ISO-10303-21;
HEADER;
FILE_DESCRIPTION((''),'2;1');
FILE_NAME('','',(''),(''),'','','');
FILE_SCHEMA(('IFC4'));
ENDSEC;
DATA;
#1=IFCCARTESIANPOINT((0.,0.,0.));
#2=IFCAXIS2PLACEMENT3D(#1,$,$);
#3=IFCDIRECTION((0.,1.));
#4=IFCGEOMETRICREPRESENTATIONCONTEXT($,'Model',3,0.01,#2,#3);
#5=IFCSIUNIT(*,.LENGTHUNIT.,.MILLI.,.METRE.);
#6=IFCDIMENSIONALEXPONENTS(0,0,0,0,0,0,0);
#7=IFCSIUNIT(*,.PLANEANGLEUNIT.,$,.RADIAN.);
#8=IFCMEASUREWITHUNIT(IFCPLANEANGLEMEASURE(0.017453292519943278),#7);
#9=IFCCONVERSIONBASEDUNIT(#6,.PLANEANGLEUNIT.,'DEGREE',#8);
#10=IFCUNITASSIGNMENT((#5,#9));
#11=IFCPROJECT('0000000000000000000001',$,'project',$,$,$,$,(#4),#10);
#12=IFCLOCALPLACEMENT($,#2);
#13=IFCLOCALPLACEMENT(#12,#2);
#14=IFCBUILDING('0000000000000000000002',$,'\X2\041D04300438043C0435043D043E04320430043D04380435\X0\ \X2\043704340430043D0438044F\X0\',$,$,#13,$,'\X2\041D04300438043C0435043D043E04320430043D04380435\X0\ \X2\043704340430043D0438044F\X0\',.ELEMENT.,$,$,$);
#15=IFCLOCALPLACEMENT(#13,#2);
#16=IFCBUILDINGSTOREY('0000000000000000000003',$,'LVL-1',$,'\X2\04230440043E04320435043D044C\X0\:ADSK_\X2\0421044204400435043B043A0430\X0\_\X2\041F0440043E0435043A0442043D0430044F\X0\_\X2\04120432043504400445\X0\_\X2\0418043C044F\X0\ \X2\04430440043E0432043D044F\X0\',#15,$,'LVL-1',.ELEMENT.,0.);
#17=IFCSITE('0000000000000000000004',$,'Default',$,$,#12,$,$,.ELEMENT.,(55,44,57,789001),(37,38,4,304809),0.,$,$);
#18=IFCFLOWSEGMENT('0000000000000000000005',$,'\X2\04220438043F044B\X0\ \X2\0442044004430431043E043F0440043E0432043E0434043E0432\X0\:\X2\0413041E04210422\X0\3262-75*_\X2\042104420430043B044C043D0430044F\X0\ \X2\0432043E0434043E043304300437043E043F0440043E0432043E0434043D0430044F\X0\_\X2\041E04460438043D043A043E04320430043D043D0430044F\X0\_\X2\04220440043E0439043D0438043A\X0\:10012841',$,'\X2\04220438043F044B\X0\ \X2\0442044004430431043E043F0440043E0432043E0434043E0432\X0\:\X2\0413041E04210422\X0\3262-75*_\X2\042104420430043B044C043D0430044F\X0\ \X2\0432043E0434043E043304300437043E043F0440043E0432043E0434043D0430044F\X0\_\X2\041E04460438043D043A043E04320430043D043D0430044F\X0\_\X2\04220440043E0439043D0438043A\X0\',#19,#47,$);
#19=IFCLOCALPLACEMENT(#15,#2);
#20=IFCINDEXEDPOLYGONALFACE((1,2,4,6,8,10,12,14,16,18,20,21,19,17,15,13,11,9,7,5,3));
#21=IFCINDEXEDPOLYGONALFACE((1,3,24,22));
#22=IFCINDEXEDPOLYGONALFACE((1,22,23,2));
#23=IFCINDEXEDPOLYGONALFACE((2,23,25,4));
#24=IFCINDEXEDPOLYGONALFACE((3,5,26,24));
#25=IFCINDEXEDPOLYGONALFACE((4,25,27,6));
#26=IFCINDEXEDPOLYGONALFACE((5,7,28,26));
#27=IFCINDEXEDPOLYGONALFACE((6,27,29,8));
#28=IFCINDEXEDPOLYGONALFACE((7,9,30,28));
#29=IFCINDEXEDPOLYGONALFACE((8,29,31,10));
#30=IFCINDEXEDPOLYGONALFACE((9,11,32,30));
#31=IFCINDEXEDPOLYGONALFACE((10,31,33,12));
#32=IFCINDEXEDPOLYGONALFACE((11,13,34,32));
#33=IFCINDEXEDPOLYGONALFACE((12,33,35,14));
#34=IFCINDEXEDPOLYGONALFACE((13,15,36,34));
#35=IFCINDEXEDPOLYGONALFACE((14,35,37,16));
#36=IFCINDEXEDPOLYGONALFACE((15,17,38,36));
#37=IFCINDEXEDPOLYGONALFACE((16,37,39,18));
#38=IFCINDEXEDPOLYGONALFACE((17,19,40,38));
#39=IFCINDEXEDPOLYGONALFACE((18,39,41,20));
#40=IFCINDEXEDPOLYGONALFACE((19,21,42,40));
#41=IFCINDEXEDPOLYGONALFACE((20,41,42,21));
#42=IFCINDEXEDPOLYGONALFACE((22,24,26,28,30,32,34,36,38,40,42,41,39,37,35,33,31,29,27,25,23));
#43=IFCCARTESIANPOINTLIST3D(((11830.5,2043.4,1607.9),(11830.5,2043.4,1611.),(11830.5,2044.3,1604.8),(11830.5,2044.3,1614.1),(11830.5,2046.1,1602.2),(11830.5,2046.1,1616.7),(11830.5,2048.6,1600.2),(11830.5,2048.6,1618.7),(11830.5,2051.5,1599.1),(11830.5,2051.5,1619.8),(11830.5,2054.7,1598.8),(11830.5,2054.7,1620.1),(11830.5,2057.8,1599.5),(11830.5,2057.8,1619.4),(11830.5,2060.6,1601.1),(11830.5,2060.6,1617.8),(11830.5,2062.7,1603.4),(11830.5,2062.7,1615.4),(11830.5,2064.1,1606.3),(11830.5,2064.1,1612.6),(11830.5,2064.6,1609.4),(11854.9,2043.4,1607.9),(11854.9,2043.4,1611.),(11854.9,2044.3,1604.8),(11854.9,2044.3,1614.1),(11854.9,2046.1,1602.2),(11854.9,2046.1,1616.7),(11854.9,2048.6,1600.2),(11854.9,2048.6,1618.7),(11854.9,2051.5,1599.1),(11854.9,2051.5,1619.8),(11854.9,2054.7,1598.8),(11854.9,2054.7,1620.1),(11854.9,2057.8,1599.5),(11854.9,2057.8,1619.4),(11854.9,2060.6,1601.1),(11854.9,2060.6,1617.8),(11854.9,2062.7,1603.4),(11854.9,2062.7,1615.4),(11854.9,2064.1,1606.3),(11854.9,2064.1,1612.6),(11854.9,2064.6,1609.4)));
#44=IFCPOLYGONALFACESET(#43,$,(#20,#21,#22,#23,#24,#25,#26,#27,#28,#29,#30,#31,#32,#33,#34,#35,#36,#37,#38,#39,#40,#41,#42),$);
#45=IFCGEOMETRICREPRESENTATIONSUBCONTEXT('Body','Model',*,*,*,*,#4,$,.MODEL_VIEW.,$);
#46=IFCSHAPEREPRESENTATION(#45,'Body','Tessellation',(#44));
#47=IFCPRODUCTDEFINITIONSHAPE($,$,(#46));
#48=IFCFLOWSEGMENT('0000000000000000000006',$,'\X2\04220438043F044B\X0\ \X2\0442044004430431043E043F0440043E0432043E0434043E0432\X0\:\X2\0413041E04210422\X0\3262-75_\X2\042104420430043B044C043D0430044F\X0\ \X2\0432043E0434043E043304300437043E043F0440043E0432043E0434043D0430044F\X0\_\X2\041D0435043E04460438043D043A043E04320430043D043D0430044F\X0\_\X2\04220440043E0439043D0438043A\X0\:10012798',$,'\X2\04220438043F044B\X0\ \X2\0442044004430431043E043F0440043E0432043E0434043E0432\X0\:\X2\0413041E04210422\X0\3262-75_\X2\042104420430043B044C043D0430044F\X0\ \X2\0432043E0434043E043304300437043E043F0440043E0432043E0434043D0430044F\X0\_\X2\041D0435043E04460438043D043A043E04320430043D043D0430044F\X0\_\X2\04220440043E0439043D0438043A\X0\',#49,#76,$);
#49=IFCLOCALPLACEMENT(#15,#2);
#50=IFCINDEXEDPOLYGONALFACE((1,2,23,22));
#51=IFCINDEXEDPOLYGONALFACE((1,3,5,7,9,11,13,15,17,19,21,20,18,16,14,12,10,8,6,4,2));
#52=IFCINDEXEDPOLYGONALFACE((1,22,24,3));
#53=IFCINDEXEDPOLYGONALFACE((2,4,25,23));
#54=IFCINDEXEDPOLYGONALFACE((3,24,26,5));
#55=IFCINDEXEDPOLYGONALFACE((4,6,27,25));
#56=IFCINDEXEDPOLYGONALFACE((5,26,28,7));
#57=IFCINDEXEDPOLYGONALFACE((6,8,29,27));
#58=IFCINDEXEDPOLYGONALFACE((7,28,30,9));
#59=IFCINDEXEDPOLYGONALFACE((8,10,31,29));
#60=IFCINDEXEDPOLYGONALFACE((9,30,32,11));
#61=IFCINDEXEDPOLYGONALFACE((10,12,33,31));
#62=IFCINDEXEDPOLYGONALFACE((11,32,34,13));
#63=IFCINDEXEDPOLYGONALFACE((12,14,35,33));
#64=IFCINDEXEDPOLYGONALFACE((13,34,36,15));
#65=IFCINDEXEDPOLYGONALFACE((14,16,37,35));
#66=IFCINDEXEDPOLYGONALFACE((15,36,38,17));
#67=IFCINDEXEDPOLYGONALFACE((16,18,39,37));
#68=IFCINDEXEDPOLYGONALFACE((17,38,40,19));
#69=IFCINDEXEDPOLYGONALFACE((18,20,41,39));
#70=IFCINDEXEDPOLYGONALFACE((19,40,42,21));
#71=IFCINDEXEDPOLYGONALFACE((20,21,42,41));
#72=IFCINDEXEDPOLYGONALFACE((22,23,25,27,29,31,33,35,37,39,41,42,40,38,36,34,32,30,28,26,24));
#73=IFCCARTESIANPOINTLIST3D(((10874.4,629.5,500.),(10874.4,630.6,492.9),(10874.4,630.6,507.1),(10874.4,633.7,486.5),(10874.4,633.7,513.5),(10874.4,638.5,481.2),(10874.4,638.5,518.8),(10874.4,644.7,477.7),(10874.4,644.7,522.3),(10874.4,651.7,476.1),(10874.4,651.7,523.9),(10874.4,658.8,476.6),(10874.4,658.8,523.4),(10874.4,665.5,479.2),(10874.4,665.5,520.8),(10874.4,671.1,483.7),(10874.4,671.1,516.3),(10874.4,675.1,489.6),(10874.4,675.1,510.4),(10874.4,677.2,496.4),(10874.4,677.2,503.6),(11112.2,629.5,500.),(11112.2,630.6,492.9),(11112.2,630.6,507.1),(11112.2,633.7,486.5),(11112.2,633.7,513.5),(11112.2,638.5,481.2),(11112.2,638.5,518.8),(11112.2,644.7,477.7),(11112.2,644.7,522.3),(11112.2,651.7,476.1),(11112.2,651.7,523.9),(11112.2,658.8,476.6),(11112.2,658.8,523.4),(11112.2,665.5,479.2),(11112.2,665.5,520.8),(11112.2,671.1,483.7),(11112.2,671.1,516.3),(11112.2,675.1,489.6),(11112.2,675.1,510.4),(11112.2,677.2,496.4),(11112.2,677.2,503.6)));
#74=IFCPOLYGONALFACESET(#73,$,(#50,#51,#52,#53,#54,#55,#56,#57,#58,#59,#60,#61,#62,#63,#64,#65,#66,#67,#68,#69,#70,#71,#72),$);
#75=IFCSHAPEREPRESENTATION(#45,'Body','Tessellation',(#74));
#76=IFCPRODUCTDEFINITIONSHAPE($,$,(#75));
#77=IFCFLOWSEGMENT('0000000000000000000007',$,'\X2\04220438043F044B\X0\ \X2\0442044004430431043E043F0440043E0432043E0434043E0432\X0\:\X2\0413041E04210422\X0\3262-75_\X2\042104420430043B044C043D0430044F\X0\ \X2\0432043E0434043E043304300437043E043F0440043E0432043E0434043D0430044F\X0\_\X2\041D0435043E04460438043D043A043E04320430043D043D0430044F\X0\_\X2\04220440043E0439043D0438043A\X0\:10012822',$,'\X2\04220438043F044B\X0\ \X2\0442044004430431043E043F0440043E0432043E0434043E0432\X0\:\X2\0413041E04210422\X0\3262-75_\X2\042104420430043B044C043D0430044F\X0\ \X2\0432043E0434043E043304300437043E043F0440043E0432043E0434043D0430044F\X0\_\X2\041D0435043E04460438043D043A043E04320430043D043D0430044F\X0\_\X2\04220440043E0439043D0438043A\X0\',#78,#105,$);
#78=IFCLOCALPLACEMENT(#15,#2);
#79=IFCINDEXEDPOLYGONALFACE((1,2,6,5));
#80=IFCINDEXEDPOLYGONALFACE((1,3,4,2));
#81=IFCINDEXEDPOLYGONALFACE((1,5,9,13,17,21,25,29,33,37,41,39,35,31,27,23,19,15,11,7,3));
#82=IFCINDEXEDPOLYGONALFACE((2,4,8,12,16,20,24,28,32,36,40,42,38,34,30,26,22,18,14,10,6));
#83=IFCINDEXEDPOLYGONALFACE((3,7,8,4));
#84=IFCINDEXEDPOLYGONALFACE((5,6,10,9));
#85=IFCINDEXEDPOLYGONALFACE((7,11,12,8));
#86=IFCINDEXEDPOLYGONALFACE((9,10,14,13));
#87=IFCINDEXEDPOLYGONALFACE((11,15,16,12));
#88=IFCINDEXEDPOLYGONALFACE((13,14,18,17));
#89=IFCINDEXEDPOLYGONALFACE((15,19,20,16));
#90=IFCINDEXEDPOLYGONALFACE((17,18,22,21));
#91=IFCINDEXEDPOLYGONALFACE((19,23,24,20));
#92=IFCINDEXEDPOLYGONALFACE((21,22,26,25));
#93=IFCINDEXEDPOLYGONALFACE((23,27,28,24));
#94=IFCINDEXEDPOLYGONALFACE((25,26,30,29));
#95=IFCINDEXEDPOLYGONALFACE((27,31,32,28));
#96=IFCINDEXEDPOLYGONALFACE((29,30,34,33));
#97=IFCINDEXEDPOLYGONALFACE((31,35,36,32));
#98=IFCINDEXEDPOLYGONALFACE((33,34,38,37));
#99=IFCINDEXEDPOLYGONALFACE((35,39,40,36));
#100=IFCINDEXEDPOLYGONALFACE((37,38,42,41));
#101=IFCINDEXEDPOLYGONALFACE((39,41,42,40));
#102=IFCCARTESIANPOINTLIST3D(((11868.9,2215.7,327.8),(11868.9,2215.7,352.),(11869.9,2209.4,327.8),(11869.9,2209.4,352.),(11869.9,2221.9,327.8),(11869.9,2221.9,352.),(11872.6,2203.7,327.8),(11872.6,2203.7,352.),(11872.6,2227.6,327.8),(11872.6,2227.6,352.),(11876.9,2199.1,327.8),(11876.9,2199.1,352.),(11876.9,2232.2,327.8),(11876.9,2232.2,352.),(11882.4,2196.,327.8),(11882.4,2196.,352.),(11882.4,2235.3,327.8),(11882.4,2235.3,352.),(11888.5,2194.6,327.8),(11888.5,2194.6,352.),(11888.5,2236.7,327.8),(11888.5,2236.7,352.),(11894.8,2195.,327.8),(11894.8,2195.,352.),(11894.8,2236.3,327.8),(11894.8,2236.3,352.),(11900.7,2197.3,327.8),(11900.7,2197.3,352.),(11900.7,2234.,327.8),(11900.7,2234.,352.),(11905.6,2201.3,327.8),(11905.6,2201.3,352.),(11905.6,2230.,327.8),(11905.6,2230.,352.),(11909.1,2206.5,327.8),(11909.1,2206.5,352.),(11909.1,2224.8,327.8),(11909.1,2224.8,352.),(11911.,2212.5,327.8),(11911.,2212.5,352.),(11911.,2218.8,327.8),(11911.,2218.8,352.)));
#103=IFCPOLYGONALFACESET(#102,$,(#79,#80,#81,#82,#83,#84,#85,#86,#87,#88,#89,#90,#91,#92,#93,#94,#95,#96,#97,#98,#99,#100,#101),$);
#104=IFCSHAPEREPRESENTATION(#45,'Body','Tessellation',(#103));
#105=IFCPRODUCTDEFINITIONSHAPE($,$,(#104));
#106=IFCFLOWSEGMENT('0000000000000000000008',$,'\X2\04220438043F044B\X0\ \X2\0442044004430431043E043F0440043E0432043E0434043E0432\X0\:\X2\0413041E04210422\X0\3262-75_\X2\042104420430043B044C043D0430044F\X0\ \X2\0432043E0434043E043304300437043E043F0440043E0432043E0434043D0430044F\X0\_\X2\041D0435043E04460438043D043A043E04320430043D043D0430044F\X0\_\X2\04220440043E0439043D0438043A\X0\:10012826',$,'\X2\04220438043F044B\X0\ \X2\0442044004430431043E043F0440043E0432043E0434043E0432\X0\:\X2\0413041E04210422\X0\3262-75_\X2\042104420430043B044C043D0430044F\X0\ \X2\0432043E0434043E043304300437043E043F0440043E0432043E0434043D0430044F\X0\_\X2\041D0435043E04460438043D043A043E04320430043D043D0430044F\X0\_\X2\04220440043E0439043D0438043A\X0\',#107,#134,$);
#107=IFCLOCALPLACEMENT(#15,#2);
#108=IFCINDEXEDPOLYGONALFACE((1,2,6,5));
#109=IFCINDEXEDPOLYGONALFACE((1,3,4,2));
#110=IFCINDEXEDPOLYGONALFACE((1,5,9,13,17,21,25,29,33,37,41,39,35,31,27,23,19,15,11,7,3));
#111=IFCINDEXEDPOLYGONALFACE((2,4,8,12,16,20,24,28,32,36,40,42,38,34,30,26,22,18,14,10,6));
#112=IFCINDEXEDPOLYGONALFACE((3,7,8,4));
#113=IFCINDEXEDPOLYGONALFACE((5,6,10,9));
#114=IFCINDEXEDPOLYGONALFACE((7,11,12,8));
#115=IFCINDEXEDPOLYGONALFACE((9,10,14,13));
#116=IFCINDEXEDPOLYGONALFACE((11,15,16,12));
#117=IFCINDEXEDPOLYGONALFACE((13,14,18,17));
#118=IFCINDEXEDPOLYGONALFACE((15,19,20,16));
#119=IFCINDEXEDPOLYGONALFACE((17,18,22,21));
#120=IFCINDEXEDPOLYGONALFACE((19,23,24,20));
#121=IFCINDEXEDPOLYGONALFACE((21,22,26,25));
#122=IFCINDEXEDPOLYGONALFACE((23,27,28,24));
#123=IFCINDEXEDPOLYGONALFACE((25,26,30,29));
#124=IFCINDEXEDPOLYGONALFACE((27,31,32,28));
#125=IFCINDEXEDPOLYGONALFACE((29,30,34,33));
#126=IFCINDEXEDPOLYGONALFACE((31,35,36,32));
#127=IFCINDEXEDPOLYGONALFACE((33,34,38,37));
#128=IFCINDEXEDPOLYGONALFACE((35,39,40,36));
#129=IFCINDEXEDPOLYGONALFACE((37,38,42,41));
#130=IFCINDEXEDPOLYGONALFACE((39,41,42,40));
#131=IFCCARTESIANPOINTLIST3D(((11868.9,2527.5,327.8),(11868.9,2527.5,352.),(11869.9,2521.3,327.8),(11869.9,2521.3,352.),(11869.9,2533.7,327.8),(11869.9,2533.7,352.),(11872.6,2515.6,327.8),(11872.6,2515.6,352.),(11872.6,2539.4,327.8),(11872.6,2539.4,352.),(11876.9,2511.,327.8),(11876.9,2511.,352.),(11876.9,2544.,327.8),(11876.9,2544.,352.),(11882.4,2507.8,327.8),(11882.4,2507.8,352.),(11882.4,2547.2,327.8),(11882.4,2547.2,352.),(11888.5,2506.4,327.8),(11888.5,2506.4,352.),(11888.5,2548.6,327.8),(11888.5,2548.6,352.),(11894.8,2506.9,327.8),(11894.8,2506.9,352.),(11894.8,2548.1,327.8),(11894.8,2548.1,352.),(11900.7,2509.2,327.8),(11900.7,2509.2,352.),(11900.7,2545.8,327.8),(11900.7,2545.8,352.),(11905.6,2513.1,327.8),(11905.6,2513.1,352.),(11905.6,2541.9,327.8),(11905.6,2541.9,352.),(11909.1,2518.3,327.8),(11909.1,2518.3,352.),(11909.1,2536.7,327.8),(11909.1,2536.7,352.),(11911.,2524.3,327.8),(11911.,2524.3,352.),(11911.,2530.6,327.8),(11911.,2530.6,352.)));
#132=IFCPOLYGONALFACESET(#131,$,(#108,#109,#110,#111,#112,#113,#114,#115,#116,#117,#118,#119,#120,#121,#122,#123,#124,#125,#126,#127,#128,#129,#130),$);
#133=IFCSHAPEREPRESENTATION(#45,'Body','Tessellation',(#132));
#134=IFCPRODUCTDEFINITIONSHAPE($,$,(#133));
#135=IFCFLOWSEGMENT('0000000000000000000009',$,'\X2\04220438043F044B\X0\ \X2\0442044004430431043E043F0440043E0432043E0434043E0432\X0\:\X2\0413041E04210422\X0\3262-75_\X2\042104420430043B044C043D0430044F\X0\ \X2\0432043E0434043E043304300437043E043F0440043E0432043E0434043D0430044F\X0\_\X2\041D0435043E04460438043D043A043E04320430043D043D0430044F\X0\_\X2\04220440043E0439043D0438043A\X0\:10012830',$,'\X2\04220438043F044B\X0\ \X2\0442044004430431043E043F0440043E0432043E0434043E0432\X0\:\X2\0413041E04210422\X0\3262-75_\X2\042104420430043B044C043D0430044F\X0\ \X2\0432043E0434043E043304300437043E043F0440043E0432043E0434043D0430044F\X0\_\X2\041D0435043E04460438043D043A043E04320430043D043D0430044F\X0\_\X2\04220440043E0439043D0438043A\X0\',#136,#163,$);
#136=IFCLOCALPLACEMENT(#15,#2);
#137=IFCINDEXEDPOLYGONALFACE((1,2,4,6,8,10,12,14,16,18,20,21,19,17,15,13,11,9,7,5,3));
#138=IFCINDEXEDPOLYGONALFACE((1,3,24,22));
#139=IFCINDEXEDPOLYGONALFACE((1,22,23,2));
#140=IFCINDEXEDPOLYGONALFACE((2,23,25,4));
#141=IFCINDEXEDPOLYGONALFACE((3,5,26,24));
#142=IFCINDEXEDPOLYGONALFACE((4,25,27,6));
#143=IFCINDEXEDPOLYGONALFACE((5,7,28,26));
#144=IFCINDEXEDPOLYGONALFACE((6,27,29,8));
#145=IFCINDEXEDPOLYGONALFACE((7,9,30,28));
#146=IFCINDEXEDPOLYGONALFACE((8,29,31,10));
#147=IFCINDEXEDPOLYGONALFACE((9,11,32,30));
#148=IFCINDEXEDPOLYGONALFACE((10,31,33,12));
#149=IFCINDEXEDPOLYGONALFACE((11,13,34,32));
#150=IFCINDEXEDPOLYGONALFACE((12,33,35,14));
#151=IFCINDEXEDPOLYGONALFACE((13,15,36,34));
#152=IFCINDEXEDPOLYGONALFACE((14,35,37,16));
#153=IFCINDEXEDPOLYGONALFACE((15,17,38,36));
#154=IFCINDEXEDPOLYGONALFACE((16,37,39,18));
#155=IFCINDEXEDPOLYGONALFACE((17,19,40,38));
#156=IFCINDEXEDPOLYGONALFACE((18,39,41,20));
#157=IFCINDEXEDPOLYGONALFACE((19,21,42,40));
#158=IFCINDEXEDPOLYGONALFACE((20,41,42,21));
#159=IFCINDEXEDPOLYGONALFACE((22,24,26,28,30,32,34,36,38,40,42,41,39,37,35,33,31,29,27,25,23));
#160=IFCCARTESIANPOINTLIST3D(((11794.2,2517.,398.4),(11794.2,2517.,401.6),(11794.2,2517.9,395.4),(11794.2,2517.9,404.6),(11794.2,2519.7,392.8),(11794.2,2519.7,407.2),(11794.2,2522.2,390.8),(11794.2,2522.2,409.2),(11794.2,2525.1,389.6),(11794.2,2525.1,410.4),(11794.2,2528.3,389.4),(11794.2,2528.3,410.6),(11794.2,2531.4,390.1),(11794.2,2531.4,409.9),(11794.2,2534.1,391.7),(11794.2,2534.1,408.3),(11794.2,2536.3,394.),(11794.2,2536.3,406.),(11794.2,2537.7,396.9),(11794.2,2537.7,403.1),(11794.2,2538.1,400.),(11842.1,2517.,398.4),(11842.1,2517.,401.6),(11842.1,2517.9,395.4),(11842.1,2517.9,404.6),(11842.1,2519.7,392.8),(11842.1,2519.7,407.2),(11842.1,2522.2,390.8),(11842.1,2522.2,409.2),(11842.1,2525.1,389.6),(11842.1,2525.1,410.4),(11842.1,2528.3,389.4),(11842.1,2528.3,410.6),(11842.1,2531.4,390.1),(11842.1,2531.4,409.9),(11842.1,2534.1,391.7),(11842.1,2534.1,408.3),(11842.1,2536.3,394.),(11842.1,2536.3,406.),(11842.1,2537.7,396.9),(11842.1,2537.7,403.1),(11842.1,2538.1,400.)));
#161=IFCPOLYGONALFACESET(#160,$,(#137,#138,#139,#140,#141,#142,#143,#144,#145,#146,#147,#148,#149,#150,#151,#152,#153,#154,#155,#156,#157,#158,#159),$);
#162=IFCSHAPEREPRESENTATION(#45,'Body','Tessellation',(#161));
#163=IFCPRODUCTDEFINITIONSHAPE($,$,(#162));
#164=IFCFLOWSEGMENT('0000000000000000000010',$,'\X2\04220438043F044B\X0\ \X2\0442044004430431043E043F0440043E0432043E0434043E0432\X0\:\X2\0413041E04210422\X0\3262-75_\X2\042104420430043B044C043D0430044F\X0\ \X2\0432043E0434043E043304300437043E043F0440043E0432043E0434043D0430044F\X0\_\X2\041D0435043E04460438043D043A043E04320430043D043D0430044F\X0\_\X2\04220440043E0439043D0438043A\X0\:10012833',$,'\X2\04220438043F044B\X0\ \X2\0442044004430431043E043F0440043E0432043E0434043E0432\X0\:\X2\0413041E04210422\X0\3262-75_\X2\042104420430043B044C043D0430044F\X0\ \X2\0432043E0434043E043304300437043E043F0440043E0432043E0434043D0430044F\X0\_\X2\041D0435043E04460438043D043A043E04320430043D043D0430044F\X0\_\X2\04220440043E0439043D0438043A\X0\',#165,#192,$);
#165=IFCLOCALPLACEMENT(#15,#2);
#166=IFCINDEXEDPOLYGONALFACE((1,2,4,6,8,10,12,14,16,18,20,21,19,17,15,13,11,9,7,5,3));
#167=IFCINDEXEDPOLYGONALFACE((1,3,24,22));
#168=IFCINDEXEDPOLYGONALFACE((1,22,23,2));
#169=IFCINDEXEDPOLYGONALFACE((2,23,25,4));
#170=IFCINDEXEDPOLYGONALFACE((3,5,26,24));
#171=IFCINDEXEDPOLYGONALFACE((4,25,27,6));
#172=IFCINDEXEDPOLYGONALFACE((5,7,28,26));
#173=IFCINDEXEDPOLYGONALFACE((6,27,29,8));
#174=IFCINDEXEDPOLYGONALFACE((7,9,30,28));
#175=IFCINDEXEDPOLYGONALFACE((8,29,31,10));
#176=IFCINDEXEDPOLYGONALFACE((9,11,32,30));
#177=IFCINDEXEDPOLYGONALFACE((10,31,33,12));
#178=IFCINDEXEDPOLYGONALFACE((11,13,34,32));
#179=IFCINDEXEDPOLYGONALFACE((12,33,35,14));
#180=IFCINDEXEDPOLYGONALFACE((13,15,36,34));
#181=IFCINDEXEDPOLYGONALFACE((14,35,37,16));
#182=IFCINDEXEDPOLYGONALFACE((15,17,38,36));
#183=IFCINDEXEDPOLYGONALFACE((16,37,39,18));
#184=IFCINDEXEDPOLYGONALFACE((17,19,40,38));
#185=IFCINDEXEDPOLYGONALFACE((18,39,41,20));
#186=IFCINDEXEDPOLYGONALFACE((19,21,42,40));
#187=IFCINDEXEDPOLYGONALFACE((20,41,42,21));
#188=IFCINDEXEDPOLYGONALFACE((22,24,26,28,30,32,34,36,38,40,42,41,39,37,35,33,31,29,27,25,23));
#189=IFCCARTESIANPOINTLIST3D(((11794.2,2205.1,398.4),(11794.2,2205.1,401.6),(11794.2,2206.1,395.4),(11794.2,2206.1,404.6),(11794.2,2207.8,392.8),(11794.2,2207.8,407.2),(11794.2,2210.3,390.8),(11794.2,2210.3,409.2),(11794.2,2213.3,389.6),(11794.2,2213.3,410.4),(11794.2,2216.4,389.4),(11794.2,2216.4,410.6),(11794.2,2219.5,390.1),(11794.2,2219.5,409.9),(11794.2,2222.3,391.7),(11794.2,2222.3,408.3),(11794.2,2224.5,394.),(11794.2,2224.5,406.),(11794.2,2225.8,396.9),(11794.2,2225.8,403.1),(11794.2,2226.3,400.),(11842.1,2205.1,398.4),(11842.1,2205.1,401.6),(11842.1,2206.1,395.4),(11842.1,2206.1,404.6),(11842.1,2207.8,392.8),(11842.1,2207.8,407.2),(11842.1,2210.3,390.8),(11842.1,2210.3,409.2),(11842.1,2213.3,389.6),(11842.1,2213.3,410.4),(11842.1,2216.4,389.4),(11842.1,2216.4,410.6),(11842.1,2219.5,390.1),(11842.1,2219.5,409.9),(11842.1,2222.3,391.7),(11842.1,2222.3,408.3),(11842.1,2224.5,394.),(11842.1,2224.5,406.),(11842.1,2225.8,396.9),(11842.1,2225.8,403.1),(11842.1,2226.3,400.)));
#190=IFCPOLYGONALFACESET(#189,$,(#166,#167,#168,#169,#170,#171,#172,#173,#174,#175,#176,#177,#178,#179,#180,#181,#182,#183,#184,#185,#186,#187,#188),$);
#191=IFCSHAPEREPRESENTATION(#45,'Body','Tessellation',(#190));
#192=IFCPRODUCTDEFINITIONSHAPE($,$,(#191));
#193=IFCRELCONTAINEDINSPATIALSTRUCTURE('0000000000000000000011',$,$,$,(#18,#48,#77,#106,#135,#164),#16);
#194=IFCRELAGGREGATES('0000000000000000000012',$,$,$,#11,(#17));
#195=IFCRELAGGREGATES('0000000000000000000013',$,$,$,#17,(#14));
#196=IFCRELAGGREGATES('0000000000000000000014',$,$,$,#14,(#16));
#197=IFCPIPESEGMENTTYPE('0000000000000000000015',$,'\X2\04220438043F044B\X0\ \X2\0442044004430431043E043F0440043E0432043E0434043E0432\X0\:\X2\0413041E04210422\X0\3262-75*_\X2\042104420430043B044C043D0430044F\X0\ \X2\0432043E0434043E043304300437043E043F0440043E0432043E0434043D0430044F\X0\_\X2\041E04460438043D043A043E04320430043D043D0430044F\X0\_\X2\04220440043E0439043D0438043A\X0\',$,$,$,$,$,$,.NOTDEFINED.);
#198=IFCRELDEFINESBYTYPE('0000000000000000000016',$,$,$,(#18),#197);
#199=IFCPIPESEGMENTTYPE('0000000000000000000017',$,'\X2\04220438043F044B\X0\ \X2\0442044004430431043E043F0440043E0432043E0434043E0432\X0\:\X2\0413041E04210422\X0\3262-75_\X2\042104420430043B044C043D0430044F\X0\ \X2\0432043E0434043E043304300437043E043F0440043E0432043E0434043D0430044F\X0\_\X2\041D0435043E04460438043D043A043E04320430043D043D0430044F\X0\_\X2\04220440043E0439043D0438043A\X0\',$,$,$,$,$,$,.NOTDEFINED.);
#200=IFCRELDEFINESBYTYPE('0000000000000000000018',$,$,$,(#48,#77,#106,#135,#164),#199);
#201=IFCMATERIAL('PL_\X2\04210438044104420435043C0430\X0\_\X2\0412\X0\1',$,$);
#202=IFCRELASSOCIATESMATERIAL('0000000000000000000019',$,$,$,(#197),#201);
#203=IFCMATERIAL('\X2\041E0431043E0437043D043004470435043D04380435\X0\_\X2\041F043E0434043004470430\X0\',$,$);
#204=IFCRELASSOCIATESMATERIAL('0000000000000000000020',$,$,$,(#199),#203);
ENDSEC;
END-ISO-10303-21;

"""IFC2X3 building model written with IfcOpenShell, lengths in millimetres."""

from ifc_helpers import new_model, entity, si_unit, converted_unit, direction, frame, frame_2d, origin, origin_2d_with_axis, place, context, subcontext, project, spatial, circle, extrude, material, type_object, element, save


model = new_model("IFC2X3")

# Units and contexts
model_context = context("Model", 3, precision=0.01, world=origin(), true_north=direction((0.0, 1.0)))
body_context = subcontext(model_context, "Body", "Model", "MODEL_VIEW")
ifc_project = project(units=[si_unit("LENGTHUNIT", "METRE", prefix="MILLI"), converted_unit("PLANEANGLEUNIT", "DEGREE", entity("IfcPlaneAngleMeasure", 0.017453292519943278), si_unit("PLANEANGLEUNIT", "RADIAN"), dimensions=[0, 0, 0, 0, 0, 0, 0])], contexts=[model_context])

# Site, building, storey
site_placement = place(None, origin())
site = spatial("IfcSite", under=ifc_project, at=site_placement, Name="Default", CompositionType="ELEMENT", RefLatitude=(55, 44, 57, 789001), RefLongitude=(37, 38, 4, 304809), RefElevation=0.0)
building_placement = place(site_placement, origin())
building = spatial("IfcBuilding", under=site, at=building_placement, Name="Наименование здания", LongName="Наименование здания", CompositionType="ELEMENT")
storey_placement = place(building_placement, origin())
storey = spatial("IfcBuildingStorey", under=building, at=storey_placement, Name="LVL-1", ObjectType="Уровень:ADSK_Стрелка_Проектная_Вверх_Имя уровня", LongName="LVL-1", CompositionType="ELEMENT", Elevation=0.0)

# Flow segments
ifc_material_1 = material(Name="PL_Система_В1")
pipe_segment_type_1 = type_object("IfcPipeSegmentType", Name="Типы трубопроводов:ГОСТ3262-75*_Стальная водогазопроводная_Оцинкованная_Тройник", PredefinedType="NOTDEFINED", material=ifc_material_1)
flow_segment_1_placement = place(storey_placement, origin())
element("IfcFlowSegment", 1, at=flow_segment_1_placement, inside=storey, type_object=pipe_segment_type_1, Name="Типы трубопроводов:ГОСТ3262-75*_Стальная водогазопроводная_Оцинкованная_Тройник:10012841", ObjectType="Типы трубопроводов:ГОСТ3262-75*_Стальная водогазопроводная_Оцинкованная_Тройник", context=body_context, shape_type="SweptSolid", body=[
    extrude(circle(Radius=10.7, at=origin_2d_with_axis()), frame((11830.5, 2053.9, 1609.4), z_axis=(1.0, 0.0, 0.0), x_axis=(0.0, 1.0, 0.0)), (0.0, 0.0, 1.0), 24.4),
])
ifc_material_2 = material(Name="Обозначение_Подача")
pipe_segment_type_2 = type_object("IfcPipeSegmentType", Name="Типы трубопроводов:ГОСТ3262-75_Стальная водогазопроводная_Неоцинкованная_Тройник", PredefinedType="NOTDEFINED", material=ifc_material_2)
flow_segment_2_placement = place(storey_placement, origin())
element("IfcFlowSegment", 2, at=flow_segment_2_placement, inside=storey, type_object=pipe_segment_type_2, Name="Типы трубопроводов:ГОСТ3262-75_Стальная водогазопроводная_Неоцинкованная_Тройник:10012798", ObjectType="Типы трубопроводов:ГОСТ3262-75_Стальная водогазопроводная_Неоцинкованная_Тройник", context=body_context, shape_type="SweptSolid", body=[
    extrude(circle(Radius=24.0, at=frame_2d((0.0, 0.0), x_axis=(1.0, 0.0))), frame((10874.4, 653.5, 500.0), z_axis=(1.0, 0.0, 0.0), x_axis=(0.0, -1.0, 0.0)), (0.0, 0.0, 1.0), 237.8),
])
flow_segment_3_placement = place(storey_placement, origin())
element("IfcFlowSegment", 3, at=flow_segment_3_placement, inside=storey, type_object=pipe_segment_type_2, Name="Типы трубопроводов:ГОСТ3262-75_Стальная водогазопроводная_Неоцинкованная_Тройник:10012822", ObjectType="Типы трубопроводов:ГОСТ3262-75_Стальная водогазопроводная_Неоцинкованная_Тройник", context=body_context, shape_type="SweptSolid", body=[
    extrude(circle(Radius=21.1, at=origin_2d_with_axis()), frame((11890.1, 2215.7, 327.8), z_axis=(0.0, 0.0, 1.0), x_axis=(-1.0, 0.0, 0.0)), (0.0, 0.0, 1.0), 24.2),
])
flow_segment_4_placement = place(storey_placement, origin())
element("IfcFlowSegment", 4, at=flow_segment_4_placement, inside=storey, type_object=pipe_segment_type_2, Name="Типы трубопроводов:ГОСТ3262-75_Стальная водогазопроводная_Неоцинкованная_Тройник:10012826", ObjectType="Типы трубопроводов:ГОСТ3262-75_Стальная водогазопроводная_Неоцинкованная_Тройник", context=body_context, shape_type="SweptSolid", body=[
    extrude(circle(Radius=21.1, at=frame_2d((0.0, 0.0), x_axis=(1.0, 0.0))), frame((11890.1, 2527.5, 327.8), z_axis=(0.0, 0.0, 1.0), x_axis=(-1.0, 0.0, 0.0)), (0.0, 0.0, 1.0), 24.2),
])
flow_segment_5_placement = place(storey_placement, origin())
element("IfcFlowSegment", 5, at=flow_segment_5_placement, inside=storey, type_object=pipe_segment_type_2, Name="Типы трубопроводов:ГОСТ3262-75_Стальная водогазопроводная_Неоцинкованная_Тройник:10012830", ObjectType="Типы трубопроводов:ГОСТ3262-75_Стальная водогазопроводная_Неоцинкованная_Тройник", context=body_context, shape_type="SweptSolid", body=[
    extrude(circle(Radius=10.7, at=origin_2d_with_axis()), frame((11794.2, 2527.5, 400.0), z_axis=(1.0, 0.0, 0.0), x_axis=(0.0, 1.0, 0.0)), (0.0, 0.0, 1.0), 47.8),
])
flow_segment_6_placement = place(storey_placement, origin())
element("IfcFlowSegment", 6, at=flow_segment_6_placement, inside=storey, type_object=pipe_segment_type_2, Name="Типы трубопроводов:ГОСТ3262-75_Стальная водогазопроводная_Неоцинкованная_Тройник:10012833", ObjectType="Типы трубопроводов:ГОСТ3262-75_Стальная водогазопроводная_Неоцинкованная_Тройник", context=body_context, shape_type="SweptSolid", body=[
    extrude(circle(Radius=10.7, at=origin_2d_with_axis()), frame((11794.2, 2215.7, 400.0), z_axis=(1.0, 0.0, 0.0), x_axis=(0.0, 1.0, 0.0)), (0.0, 0.0, 1.0), 47.8),
])

save(model, "model.ifc")
